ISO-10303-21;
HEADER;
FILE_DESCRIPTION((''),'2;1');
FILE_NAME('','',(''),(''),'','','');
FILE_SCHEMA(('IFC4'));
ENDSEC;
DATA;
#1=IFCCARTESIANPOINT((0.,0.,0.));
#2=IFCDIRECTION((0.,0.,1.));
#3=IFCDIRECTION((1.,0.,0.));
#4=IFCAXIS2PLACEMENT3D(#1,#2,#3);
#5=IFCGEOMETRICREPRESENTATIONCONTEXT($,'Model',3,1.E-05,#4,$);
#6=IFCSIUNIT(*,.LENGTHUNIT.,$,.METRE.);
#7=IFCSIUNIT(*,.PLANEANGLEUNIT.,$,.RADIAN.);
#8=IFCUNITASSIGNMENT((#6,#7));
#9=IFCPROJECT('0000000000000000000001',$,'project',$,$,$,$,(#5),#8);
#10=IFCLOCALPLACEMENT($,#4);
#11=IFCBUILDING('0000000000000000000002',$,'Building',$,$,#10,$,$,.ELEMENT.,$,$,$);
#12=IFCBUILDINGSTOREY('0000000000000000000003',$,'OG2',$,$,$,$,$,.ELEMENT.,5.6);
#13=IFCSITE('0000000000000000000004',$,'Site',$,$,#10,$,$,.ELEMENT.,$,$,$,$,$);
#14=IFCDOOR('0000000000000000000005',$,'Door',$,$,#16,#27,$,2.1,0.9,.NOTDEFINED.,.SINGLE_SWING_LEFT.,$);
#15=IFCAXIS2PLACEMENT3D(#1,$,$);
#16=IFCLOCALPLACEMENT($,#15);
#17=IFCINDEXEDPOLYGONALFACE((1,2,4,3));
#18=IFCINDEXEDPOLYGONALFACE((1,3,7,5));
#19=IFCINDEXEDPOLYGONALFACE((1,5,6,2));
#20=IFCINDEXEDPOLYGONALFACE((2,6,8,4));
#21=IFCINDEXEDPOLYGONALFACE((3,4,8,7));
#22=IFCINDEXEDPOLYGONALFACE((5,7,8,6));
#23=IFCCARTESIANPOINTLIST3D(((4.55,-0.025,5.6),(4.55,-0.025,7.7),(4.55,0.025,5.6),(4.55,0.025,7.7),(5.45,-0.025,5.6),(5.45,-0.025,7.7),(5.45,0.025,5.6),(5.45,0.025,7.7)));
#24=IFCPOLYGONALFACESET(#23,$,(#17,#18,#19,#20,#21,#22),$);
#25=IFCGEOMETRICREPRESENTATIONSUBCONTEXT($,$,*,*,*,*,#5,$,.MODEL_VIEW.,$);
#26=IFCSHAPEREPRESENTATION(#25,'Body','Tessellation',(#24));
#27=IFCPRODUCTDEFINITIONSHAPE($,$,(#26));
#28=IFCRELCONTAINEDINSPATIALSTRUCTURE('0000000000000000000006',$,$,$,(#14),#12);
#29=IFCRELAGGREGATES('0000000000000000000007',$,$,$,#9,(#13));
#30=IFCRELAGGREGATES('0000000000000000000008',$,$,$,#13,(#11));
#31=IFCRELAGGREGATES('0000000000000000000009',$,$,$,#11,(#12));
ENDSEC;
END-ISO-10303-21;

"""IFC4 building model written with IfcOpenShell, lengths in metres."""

from ifc_helpers import new_model, si_unit, frame, origin, origin_with_axes, origin_2d, place, context, subcontext, project, spatial, rectangle, extrude, element, save


model = new_model("IFC4")

# Units and contexts
model_context = context("Model", 3, precision=1e-05, world=origin_with_axes())
sub_context = subcontext(model_context, None, None, "MODEL_VIEW")
ifc_project = project(units=[si_unit("LENGTHUNIT", "METRE"), si_unit("PLANEANGLEUNIT", "RADIAN")], contexts=[model_context])

# Site, building, storey
placement_1 = place(None, origin_with_axes())
site = spatial("IfcSite", under=ifc_project, at=placement_1, Name="Site", CompositionType="ELEMENT")
building = spatial("IfcBuilding", under=site, at=placement_1, Name="Building", CompositionType="ELEMENT")
storey = spatial("IfcBuildingStorey", under=building, Name="OG2", CompositionType="ELEMENT", Elevation=5.6)

# Door
placement_2 = place(None, origin_with_axes())
door_placement = place(placement_2, frame((5.0, 0.0, 5.6)))
element("IfcDoor", 1, at=door_placement, inside=storey, Name="Door", OperationType="SINGLE_SWING_LEFT", OverallHeight=2.1, OverallWidth=0.9, PredefinedType="NOTDEFINED", context=sub_context, shape_type="SweptSolid", body=[
    extrude(rectangle(XDim=0.9, YDim=0.05, at=origin_2d()), origin(), (0.0, 0.0, 1.0), 2.1),
])

save(model, "model.ifc")
